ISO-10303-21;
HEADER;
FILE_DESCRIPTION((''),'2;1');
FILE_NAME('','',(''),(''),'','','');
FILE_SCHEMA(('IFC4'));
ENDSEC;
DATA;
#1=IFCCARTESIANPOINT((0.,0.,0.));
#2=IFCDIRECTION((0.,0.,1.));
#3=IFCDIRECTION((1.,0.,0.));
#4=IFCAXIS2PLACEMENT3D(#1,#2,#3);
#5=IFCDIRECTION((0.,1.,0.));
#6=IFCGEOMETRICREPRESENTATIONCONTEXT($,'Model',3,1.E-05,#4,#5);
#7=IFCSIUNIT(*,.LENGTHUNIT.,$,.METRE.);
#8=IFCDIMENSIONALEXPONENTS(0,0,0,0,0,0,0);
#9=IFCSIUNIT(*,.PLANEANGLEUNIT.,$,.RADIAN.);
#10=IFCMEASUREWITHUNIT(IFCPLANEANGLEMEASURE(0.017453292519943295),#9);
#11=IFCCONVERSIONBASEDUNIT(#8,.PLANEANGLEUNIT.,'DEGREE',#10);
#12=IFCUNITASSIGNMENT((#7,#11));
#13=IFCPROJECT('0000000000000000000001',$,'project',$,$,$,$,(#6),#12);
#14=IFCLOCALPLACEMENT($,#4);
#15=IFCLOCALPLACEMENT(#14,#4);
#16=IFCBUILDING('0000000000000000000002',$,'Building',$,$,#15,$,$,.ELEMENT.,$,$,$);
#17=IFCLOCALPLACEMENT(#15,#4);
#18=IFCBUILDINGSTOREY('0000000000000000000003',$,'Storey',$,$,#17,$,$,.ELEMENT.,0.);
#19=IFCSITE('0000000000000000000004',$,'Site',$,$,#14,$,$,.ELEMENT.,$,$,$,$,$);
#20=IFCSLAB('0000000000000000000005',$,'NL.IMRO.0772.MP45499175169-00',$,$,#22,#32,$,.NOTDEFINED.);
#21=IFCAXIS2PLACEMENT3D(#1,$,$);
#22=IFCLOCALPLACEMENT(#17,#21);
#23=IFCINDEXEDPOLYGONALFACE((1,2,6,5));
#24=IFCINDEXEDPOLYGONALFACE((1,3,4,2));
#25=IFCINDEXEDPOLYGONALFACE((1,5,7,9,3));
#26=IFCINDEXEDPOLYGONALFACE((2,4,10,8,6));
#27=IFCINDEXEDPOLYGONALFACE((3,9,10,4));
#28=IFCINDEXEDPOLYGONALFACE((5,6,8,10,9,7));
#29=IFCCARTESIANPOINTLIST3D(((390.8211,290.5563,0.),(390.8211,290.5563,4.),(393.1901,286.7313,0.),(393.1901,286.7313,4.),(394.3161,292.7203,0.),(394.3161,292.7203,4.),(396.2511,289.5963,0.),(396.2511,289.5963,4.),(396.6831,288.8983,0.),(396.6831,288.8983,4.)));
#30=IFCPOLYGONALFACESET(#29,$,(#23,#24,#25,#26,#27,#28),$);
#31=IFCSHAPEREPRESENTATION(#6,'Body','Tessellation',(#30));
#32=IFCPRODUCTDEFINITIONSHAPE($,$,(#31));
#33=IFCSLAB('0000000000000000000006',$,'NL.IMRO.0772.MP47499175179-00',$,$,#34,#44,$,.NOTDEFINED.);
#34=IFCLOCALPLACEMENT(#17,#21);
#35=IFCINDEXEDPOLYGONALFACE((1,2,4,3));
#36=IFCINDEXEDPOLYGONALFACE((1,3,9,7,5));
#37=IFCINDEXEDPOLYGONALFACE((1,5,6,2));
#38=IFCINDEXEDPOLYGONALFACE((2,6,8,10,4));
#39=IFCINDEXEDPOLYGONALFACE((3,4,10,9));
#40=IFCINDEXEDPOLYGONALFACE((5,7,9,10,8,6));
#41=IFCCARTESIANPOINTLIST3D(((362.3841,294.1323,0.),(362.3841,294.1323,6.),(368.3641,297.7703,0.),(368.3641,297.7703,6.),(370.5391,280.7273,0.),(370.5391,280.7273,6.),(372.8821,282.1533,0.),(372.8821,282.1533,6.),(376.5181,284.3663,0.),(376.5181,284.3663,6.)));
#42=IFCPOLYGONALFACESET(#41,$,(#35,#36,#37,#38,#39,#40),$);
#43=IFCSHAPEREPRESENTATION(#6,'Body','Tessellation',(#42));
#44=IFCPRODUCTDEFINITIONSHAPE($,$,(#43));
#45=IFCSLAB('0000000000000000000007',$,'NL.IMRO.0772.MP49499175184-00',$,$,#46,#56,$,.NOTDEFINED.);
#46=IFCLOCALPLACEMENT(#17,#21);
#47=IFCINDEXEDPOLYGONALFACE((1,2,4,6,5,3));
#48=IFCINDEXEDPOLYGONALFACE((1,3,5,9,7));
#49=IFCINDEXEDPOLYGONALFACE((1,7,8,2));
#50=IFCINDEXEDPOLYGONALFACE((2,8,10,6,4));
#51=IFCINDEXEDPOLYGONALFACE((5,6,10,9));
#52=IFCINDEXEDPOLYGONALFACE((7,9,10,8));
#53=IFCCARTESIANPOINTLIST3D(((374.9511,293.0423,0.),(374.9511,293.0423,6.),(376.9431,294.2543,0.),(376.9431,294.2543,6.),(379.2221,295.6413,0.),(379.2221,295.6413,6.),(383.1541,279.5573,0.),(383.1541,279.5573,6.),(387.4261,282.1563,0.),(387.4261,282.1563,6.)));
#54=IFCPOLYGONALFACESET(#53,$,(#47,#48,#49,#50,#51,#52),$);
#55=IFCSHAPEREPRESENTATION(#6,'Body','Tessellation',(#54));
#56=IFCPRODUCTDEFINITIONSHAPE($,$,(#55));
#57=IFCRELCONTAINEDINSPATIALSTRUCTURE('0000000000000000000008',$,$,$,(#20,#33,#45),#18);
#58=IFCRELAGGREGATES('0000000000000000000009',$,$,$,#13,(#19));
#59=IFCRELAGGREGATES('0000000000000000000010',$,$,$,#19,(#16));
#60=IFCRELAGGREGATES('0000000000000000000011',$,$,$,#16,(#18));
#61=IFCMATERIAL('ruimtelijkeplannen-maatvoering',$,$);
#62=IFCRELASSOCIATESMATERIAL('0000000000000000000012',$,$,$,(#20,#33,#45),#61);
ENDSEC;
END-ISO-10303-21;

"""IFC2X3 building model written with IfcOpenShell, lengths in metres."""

from ifc_helpers import new_model, entity, si_unit, converted_unit, direction, origin_with_axes, place, context, project, spatial, polyline, outline, extrude, material, element, save


model = new_model("IFC2X3")

# Units and contexts
model_context = context("Model", 3, precision=1e-05, world=origin_with_axes(), true_north=direction((0.0, 1.0, 0.0)))
ifc_project = project(units=[si_unit("LENGTHUNIT", "METRE"), converted_unit("PLANEANGLEUNIT", "DEGREE", entity("IfcPlaneAngleMeasure", 0.017453292519943295), si_unit("PLANEANGLEUNIT", "RADIAN"), dimensions=[0, 0, 0, 0, 0, 0, 0])], contexts=[model_context])

# Site, building, storey
site_placement = place(None, origin_with_axes())
site = spatial("IfcSite", under=ifc_project, at=site_placement, Name="Site", CompositionType="ELEMENT")
building_placement = place(site_placement, origin_with_axes())
building = spatial("IfcBuilding", under=site, at=building_placement, Name="Building", CompositionType="ELEMENT")
storey_placement = place(building_placement, origin_with_axes())
storey = spatial("IfcBuildingStorey", under=building, at=storey_placement, Name="Storey", CompositionType="ELEMENT", Elevation=0.0)

# Slabs
ifc_material = material(Name="ruimtelijkeplannen-maatvoering")
slab_1_placement = place(storey_placement, origin_with_axes())
element("IfcSlab", 1, at=slab_1_placement, inside=storey, material=ifc_material, Name="NL.IMRO.0772.MP45499175169-00", PredefinedType="NOTDEFINED", context=model_context, shape_type="SweptSolid", body=[
    extrude(outline(polyline([(396.6831, 288.8983), (393.1901, 286.7313), (390.8211, 290.5563), (394.3161, 292.7203), (396.2511, 289.5963), (396.6831, 288.8983)])), origin_with_axes(), (0.0, 0.0, 1.0), 4.0),
])
slab_2_placement = place(storey_placement, origin_with_axes())
element("IfcSlab", 2, at=slab_2_placement, inside=storey, material=ifc_material, Name="NL.IMRO.0772.MP47499175179-00", PredefinedType="NOTDEFINED", context=model_context, shape_type="SweptSolid", body=[
    extrude(outline(polyline([(376.5181, 284.3663), (372.8821, 282.1533), (370.5391, 280.7273), (362.3841, 294.1323), (368.3641, 297.7703), (376.5181, 284.3663)])), origin_with_axes(), (0.0, 0.0, 1.0), 6.0),
])
slab_3_placement = place(storey_placement, origin_with_axes())
element("IfcSlab", 3, at=slab_3_placement, inside=storey, material=ifc_material, Name="NL.IMRO.0772.MP49499175184-00", PredefinedType="NOTDEFINED", context=model_context, shape_type="SweptSolid", body=[
    extrude(outline(polyline([(374.9511, 293.0423), (376.9431, 294.2543), (379.2221, 295.6413), (387.4261, 282.1563), (383.1541, 279.5573), (374.9511, 293.0423)])), origin_with_axes(), (0.0, 0.0, 1.0), 6.0),
])

save(model, "model.ifc")
